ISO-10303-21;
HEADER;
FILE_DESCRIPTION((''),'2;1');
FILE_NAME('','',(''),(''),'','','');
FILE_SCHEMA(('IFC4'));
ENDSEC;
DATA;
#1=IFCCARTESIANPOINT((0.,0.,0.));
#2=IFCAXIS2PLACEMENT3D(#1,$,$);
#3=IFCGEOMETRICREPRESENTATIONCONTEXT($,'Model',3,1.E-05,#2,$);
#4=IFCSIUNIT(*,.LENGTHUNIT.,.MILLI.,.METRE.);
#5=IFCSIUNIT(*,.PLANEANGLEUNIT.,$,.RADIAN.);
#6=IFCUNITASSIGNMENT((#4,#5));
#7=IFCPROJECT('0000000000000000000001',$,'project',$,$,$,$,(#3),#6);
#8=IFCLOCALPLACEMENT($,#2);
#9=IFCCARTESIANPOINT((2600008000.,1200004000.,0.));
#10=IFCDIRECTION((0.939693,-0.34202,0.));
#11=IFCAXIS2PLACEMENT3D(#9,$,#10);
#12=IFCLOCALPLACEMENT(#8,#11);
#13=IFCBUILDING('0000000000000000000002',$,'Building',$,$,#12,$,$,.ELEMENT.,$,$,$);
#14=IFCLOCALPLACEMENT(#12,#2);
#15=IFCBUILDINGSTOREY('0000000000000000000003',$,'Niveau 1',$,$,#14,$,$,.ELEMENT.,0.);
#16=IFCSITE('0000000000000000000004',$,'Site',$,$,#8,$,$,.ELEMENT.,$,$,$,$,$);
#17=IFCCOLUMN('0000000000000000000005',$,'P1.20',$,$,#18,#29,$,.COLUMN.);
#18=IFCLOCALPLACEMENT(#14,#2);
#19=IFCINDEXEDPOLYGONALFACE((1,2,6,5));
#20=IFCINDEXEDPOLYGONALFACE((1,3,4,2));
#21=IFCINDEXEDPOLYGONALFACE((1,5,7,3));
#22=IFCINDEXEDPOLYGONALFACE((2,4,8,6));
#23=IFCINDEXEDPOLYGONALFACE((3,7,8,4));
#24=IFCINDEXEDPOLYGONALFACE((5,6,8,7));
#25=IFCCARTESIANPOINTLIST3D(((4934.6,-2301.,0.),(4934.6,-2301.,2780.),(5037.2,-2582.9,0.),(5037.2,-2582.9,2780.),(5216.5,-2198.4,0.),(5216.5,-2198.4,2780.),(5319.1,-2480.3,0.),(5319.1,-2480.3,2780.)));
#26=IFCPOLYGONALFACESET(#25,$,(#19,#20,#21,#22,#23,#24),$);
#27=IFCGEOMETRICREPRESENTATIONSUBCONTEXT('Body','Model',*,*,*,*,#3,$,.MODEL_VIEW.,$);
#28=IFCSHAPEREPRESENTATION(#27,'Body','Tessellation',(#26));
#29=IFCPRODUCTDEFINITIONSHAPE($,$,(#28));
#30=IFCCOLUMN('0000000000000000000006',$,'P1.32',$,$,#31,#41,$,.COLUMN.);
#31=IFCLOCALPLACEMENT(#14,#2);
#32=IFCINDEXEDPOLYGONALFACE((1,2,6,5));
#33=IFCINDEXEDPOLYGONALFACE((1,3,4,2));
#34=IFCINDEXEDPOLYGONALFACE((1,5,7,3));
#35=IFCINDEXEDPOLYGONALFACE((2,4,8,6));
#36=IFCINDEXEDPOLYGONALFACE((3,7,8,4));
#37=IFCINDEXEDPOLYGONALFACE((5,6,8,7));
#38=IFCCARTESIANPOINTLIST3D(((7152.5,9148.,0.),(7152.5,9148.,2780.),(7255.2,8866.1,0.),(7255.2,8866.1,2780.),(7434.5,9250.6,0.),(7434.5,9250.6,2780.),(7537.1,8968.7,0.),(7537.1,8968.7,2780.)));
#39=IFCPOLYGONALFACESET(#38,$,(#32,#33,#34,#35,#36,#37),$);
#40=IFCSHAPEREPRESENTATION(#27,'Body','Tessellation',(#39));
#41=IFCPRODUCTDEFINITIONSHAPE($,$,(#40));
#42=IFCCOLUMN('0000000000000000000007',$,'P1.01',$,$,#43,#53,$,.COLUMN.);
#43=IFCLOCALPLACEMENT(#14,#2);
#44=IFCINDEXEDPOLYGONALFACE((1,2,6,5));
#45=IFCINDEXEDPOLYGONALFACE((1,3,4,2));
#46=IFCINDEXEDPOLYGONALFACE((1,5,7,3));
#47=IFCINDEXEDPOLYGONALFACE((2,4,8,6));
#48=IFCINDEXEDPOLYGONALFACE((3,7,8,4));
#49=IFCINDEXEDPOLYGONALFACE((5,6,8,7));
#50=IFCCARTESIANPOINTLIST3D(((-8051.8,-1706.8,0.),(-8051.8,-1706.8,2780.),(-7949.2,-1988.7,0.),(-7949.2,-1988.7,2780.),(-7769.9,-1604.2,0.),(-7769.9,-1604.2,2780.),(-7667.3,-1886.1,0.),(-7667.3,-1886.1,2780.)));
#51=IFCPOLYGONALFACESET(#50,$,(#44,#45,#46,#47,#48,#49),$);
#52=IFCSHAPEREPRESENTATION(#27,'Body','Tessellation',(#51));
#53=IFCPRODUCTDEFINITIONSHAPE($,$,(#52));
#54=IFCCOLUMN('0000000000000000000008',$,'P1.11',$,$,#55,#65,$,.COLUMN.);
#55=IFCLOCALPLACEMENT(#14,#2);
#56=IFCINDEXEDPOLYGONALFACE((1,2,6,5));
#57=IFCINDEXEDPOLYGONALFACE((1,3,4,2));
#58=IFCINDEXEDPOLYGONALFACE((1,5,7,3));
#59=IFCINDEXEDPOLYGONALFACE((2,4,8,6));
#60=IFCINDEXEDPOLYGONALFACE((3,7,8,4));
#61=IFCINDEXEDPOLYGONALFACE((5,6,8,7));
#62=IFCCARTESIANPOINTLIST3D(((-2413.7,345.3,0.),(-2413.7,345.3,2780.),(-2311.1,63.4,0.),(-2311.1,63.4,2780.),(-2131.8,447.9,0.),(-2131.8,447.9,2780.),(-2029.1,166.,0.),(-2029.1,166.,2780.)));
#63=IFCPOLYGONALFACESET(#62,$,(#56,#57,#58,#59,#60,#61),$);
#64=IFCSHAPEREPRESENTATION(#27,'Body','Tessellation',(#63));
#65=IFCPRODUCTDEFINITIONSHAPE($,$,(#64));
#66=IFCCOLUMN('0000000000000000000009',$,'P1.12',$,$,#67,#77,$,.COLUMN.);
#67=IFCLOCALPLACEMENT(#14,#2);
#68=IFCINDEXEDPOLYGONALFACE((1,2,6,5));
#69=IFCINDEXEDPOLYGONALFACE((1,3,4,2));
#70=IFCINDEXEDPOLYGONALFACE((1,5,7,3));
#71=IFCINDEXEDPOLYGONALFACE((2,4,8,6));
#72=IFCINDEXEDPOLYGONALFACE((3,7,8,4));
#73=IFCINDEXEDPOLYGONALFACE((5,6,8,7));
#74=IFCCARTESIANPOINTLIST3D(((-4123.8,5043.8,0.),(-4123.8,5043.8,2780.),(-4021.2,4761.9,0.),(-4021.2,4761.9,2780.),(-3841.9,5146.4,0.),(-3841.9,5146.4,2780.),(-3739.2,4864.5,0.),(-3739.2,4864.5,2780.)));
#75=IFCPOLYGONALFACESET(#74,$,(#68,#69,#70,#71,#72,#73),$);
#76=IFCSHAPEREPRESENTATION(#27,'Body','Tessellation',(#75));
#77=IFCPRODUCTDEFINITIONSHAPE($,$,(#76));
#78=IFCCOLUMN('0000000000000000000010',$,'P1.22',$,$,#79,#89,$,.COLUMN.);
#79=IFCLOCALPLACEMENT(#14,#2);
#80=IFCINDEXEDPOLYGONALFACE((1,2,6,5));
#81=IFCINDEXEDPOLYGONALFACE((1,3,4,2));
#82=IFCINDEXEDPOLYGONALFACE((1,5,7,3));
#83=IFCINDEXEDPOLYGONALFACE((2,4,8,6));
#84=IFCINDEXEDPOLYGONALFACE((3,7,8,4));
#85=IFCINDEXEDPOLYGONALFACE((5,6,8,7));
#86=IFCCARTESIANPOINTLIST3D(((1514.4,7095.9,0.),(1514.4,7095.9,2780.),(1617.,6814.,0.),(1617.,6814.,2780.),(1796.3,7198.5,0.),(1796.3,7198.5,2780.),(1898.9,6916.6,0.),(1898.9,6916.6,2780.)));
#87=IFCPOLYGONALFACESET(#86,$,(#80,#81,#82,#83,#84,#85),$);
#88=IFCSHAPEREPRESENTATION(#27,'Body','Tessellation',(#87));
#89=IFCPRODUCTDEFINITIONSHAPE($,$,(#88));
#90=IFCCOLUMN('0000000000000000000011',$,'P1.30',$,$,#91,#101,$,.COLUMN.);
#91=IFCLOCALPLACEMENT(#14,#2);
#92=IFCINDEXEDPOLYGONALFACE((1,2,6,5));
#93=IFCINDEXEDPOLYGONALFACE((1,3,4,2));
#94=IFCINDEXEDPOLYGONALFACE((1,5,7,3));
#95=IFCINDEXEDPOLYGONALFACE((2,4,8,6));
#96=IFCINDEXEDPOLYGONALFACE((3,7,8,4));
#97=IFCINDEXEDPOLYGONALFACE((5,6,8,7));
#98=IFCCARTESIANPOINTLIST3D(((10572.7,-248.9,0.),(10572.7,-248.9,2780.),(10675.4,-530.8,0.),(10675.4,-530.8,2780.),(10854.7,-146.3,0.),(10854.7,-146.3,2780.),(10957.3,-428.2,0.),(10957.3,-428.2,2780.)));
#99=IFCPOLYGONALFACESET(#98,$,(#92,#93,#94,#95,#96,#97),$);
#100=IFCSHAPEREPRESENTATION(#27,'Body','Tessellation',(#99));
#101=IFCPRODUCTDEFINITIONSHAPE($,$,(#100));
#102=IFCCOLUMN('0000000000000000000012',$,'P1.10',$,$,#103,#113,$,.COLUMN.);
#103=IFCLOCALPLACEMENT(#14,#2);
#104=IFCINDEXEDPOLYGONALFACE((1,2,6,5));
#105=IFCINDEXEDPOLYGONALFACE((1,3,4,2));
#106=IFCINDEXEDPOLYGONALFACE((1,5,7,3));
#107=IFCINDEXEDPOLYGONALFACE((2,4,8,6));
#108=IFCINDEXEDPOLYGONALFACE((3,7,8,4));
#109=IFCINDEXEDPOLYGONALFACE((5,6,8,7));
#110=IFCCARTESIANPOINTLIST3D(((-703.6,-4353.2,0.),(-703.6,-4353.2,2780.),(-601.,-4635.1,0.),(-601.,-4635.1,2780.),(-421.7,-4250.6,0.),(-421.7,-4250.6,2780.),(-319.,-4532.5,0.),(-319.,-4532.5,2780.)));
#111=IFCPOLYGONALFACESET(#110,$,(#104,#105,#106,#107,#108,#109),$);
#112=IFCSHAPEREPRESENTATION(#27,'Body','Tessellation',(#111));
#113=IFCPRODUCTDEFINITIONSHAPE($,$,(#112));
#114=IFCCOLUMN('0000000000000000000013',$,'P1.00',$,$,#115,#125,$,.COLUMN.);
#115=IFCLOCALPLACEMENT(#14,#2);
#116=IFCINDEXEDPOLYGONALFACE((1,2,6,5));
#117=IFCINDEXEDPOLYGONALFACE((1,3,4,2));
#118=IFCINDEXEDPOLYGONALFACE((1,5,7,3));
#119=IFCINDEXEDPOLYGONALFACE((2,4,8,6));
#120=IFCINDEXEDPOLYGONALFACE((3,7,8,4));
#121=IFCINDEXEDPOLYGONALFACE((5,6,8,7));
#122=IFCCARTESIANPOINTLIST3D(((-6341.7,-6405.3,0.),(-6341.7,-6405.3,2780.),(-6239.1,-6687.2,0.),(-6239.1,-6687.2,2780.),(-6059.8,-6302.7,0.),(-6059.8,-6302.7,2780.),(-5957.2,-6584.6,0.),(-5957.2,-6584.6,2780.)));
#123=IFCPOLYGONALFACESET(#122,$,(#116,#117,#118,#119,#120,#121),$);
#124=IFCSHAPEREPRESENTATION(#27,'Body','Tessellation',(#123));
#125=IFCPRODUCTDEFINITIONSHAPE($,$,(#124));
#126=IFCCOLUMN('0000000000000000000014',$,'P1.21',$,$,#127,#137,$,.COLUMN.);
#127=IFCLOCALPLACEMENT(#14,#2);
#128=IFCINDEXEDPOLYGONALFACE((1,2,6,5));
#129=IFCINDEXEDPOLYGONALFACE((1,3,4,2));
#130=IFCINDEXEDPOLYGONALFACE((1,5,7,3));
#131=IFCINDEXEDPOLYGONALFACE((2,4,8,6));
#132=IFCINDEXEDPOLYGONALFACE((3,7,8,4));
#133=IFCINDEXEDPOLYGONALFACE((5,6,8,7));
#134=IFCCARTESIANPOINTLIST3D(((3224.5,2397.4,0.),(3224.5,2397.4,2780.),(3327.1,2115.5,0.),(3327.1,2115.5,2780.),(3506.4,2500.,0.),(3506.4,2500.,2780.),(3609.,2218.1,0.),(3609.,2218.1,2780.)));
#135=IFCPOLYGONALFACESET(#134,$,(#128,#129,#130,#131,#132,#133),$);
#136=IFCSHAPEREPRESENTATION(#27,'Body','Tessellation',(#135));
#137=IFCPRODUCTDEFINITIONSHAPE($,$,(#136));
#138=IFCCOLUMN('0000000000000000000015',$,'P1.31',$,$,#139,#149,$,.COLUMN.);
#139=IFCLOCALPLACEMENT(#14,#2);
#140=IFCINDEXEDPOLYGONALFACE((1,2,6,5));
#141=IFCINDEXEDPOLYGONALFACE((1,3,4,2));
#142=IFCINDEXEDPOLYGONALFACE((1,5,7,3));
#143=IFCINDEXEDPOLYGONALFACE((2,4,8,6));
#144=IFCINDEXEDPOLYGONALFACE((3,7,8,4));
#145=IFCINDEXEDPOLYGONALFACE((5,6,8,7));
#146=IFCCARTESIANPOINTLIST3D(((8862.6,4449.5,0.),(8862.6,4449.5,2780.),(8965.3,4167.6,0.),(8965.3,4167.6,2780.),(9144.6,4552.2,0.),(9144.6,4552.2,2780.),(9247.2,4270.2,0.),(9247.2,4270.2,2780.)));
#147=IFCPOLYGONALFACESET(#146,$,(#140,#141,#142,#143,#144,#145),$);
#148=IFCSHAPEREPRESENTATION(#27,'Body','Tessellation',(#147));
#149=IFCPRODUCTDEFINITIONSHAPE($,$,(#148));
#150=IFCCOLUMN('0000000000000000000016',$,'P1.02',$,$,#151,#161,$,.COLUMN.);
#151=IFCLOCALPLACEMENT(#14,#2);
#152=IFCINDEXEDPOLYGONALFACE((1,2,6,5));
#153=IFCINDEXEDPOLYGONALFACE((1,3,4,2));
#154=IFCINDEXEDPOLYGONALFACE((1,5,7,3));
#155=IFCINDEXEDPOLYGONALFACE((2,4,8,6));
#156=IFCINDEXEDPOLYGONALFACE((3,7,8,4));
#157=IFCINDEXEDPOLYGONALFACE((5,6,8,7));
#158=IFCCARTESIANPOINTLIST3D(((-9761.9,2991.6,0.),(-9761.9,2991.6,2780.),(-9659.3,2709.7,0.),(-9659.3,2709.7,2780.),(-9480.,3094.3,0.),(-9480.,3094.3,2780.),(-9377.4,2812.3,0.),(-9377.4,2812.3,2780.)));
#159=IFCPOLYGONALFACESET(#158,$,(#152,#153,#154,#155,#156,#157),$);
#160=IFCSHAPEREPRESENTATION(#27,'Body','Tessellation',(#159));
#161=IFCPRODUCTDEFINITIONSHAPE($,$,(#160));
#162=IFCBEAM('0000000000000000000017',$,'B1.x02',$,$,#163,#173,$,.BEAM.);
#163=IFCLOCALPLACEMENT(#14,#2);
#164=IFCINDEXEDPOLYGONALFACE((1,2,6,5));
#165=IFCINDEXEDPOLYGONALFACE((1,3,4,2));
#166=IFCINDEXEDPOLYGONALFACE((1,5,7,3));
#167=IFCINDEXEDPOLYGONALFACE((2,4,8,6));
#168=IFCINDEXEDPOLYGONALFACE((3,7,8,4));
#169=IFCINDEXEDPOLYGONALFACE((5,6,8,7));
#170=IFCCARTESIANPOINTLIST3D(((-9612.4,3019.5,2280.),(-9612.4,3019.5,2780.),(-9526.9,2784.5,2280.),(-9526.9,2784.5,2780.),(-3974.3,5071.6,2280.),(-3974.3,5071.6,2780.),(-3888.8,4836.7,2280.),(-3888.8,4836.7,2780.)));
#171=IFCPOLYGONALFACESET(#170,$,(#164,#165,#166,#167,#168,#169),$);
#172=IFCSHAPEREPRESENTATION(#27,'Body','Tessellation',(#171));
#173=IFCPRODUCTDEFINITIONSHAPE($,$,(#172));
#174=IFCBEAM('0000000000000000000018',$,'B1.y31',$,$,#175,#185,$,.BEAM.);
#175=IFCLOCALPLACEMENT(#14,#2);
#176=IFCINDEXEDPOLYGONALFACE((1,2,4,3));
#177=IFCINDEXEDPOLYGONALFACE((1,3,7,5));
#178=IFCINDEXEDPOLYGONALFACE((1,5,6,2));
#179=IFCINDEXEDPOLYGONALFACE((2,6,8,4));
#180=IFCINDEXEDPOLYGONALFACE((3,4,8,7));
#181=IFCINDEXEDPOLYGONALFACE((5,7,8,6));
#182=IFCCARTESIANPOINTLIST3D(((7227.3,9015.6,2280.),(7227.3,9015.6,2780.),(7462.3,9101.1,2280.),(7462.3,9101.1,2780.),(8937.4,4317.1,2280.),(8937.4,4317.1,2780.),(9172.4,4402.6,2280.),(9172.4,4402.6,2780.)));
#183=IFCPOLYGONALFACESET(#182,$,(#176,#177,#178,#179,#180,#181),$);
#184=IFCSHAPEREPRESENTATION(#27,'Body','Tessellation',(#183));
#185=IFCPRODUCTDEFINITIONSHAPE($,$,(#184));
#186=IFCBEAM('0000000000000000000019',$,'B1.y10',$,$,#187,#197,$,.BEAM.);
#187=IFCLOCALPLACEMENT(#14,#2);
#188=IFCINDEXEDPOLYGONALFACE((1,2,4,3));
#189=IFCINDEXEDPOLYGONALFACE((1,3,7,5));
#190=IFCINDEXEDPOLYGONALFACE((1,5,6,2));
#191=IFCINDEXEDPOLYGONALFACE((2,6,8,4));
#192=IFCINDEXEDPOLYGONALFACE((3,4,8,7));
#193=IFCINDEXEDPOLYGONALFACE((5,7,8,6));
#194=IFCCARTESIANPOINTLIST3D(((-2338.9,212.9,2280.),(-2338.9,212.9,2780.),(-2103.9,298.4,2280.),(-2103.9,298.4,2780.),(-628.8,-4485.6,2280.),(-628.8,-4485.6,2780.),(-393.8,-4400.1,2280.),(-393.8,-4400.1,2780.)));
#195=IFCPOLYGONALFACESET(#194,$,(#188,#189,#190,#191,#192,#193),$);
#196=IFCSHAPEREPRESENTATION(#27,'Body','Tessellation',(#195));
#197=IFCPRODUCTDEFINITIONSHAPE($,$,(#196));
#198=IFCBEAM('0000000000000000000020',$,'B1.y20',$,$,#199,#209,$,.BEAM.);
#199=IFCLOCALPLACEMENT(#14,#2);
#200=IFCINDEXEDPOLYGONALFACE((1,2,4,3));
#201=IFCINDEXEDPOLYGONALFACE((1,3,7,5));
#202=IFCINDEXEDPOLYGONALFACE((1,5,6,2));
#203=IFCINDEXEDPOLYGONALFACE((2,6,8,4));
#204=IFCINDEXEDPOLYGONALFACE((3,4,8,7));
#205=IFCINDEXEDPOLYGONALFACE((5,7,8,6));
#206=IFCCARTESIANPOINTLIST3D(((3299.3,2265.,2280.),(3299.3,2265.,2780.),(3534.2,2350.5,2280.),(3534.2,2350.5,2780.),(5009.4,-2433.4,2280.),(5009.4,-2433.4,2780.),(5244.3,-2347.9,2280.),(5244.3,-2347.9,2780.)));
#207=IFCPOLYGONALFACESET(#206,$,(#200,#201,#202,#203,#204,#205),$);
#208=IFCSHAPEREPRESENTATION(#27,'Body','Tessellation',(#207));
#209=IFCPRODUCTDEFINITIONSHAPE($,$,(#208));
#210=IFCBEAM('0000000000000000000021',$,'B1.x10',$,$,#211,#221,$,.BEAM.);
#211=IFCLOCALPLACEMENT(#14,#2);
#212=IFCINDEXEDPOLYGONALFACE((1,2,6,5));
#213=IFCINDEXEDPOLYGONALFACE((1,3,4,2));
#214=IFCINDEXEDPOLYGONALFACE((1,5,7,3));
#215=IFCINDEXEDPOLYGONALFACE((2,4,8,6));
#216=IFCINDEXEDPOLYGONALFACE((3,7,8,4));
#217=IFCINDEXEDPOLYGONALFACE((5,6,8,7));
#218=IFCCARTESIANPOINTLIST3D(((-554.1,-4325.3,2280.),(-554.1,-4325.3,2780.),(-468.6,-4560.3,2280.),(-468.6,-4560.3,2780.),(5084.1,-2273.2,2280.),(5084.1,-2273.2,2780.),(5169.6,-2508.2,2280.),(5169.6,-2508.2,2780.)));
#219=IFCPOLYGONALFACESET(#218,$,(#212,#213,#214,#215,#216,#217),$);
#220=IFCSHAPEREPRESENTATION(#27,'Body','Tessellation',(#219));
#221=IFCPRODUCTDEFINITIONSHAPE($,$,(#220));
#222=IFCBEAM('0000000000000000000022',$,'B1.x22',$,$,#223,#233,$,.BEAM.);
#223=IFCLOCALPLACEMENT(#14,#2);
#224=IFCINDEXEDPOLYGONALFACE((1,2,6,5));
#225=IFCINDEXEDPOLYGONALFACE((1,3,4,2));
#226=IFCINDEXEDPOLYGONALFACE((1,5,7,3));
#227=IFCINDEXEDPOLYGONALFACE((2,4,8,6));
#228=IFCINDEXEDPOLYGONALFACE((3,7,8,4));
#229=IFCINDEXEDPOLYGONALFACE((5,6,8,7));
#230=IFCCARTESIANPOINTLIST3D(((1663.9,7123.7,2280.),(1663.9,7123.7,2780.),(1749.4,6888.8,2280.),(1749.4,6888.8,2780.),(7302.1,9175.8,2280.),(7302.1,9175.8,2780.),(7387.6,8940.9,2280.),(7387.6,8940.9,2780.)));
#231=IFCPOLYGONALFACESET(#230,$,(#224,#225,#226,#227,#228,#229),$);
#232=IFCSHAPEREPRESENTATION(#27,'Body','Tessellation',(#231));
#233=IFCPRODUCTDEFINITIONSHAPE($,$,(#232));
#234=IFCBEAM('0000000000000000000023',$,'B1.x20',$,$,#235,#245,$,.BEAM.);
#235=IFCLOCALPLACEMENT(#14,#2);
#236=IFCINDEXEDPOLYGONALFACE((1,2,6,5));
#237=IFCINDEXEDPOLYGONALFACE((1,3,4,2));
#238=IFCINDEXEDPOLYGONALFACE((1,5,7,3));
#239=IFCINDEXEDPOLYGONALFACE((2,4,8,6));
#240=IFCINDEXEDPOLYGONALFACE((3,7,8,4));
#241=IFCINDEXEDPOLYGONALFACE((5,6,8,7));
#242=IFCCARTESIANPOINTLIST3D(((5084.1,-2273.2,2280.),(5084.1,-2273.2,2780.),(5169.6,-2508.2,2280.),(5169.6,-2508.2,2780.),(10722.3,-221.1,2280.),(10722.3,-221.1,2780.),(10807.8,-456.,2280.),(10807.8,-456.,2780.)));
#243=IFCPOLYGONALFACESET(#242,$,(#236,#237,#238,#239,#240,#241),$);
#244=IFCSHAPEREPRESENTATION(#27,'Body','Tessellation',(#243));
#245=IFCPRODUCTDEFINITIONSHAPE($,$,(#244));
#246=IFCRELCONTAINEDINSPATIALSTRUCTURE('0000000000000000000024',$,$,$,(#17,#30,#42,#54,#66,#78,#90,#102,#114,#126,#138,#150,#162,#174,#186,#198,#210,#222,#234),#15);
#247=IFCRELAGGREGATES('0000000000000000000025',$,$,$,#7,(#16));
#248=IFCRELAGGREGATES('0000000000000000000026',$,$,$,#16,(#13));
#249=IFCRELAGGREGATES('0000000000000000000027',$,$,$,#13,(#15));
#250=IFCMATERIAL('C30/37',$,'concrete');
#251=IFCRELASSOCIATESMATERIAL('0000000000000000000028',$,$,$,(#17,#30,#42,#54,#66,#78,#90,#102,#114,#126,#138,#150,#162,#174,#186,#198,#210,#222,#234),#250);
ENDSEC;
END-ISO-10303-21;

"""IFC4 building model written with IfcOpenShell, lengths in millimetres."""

from ifc_helpers import new_model, si_unit, frame, origin, place, context, subcontext, project, spatial, rectangle, extrude, material, element, save


model = new_model("IFC4")

# Units and contexts
model_context = context("Model", 3, precision=1e-05, world=origin())
body_context = subcontext(model_context, "Body", "Model", "MODEL_VIEW")
ifc_project = project(units=[si_unit("LENGTHUNIT", "METRE", prefix="MILLI"), si_unit("PLANEANGLEUNIT", "RADIAN")], contexts=[model_context])

# Site, building, storey
site_placement = place(None, origin())
site = spatial("IfcSite", under=ifc_project, at=site_placement, Name="Site", CompositionType="ELEMENT")
building_placement = place(site_placement, frame((2600008000.0, 1200004000.0, 0.0), x_axis=(0.939693, -0.34202, 0.0)))
building = spatial("IfcBuilding", under=site, at=building_placement, Name="Building", CompositionType="ELEMENT")
storey_placement = place(building_placement, origin())
storey = spatial("IfcBuildingStorey", under=building, at=storey_placement, Name="Niveau 1", CompositionType="ELEMENT", Elevation=0.0)

# Columns
ifc_material = material(Name="C30/37", Category="concrete")
for number, where, z_axis, x_axis, name in (
    (1, (5126.9, -2390.7, 0.0), (0.0, 0.0, 1.0), (0.939693, 0.34202, 0.0), "P1.20"),
    (2, (7344.8, 9058.4, 0.0), (0.0, 0.0, 1.0), (0.939693, 0.34202, 0.0), "P1.32"),
    (3, (-7859.6, -1796.5, 0.0), (0.0, 0.0, 1.0), (0.939693, 0.34202, 0.0), "P1.01"),
    (4, (-2221.4, 255.7, 0.0), (0.0, 0.0, 1.0), (0.939693, 0.34202, 0.0), "P1.11"),
    (5, (-3931.5, 4954.1, 0.0), (0.0, 0.0, 1.0), (0.939693, 0.34202, 0.0), "P1.12"),
    (6, (1706.6, 7006.2, 0.0), (0.0, 0.0, 1.0), (0.939693, 0.34202, 0.0), "P1.22"),
    (7, (10765.0, -338.6, 0.0), (0.0, 0.0, 1.0), (0.939693, 0.34202, 0.0), "P1.30"),
    (8, (-511.3, -4442.8, 0.0), (0.0, 0.0, 1.0), (0.939693, 0.34202, 0.0), "P1.10"),
    (9, (-6149.5, -6494.9, 0.0), (0.0, 0.0, 1.0), (0.939693, 0.34202, 0.0), "P1.00"),
    (10, (3416.8, 2307.8, 0.0), (0.0, 0.0, 1.0), (0.939693, 0.34202, 0.0), "P1.21"),
    (11, (9054.9, 4359.9, 0.0), (0.0, 0.0, 1.0), (0.939693, 0.34202, 0.0), "P1.31"),
    (12, (-9569.7, 2902.0, 0.0), (0.0, 0.0, 1.0), (0.939693, 0.34202, 0.0), "P1.02"),
):
    element("IfcColumn", number, at=place(storey_placement, frame(where, z_axis=z_axis, x_axis=x_axis)), inside=storey, material=ifc_material, Name=name, PredefinedType="COLUMN", context=body_context, shape_type="SweptSolid", body=[
        extrude(rectangle(XDim=300.0, YDim=300.0), origin(), (0.0, 0.0, 1.0), 2780.0),
    ])

# Beams
beam_1_placement = place(storey_placement, frame((-9569.7, 2902.0, 2530.0), z_axis=(0.939693, 0.34202, 0.0), x_axis=(-0.34202, 0.939693, 0.0)))
element("IfcBeam", 13, at=beam_1_placement, inside=storey, material=ifc_material, Name="B1.x02", PredefinedType="BEAM", context=body_context, shape_type="SweptSolid", body=[
    extrude(rectangle(XDim=250.0, YDim=500.0), origin(), (0.0, 0.0, 1.0), 6000.0),
])
for number, where, z_axis, x_axis, name in (
    (14, (9054.9, 4359.9, 2530.0), (-0.34202, 0.939693, 0.0), (-0.939693, -0.34202, 0.0), "B1.y31"),
    (15, (-511.3, -4442.8, 2530.0), (-0.34202, 0.939693, 0.0), (-0.939693, -0.34202, 0.0), "B1.y10"),
    (16, (5126.9, -2390.7, 2530.0), (-0.34202, 0.939693, 0.0), (-0.939693, -0.34202, 0.0), "B1.y20"),
):
    element("IfcBeam", number, at=place(storey_placement, frame(where, z_axis=z_axis, x_axis=x_axis)), inside=storey, material=ifc_material, Name=name, PredefinedType="BEAM", context=body_context, shape_type="SweptSolid", body=[
        extrude(rectangle(XDim=250.0, YDim=500.0), origin(), (0.0, 0.0, 1.0), 5000.0),
    ])
for number, where, z_axis, x_axis, name in (
    (17, (-511.3, -4442.8, 2530.0), (0.939693, 0.34202, 0.0), (-0.34202, 0.939693, 0.0), "B1.x10"),
    (18, (1706.6, 7006.2, 2530.0), (0.939693, 0.34202, 0.0), (-0.34202, 0.939693, 0.0), "B1.x22"),
    (19, (5126.9, -2390.7, 2530.0), (0.939693, 0.34202, 0.0), (-0.34202, 0.939693, 0.0), "B1.x20"),
):
    element("IfcBeam", number, at=place(storey_placement, frame(where, z_axis=z_axis, x_axis=x_axis)), inside=storey, material=ifc_material, Name=name, PredefinedType="BEAM", context=body_context, shape_type="SweptSolid", body=[
        extrude(rectangle(XDim=250.0, YDim=500.0), origin(), (0.0, 0.0, 1.0), 6000.0),
    ])

save(model, "model.ifc")
